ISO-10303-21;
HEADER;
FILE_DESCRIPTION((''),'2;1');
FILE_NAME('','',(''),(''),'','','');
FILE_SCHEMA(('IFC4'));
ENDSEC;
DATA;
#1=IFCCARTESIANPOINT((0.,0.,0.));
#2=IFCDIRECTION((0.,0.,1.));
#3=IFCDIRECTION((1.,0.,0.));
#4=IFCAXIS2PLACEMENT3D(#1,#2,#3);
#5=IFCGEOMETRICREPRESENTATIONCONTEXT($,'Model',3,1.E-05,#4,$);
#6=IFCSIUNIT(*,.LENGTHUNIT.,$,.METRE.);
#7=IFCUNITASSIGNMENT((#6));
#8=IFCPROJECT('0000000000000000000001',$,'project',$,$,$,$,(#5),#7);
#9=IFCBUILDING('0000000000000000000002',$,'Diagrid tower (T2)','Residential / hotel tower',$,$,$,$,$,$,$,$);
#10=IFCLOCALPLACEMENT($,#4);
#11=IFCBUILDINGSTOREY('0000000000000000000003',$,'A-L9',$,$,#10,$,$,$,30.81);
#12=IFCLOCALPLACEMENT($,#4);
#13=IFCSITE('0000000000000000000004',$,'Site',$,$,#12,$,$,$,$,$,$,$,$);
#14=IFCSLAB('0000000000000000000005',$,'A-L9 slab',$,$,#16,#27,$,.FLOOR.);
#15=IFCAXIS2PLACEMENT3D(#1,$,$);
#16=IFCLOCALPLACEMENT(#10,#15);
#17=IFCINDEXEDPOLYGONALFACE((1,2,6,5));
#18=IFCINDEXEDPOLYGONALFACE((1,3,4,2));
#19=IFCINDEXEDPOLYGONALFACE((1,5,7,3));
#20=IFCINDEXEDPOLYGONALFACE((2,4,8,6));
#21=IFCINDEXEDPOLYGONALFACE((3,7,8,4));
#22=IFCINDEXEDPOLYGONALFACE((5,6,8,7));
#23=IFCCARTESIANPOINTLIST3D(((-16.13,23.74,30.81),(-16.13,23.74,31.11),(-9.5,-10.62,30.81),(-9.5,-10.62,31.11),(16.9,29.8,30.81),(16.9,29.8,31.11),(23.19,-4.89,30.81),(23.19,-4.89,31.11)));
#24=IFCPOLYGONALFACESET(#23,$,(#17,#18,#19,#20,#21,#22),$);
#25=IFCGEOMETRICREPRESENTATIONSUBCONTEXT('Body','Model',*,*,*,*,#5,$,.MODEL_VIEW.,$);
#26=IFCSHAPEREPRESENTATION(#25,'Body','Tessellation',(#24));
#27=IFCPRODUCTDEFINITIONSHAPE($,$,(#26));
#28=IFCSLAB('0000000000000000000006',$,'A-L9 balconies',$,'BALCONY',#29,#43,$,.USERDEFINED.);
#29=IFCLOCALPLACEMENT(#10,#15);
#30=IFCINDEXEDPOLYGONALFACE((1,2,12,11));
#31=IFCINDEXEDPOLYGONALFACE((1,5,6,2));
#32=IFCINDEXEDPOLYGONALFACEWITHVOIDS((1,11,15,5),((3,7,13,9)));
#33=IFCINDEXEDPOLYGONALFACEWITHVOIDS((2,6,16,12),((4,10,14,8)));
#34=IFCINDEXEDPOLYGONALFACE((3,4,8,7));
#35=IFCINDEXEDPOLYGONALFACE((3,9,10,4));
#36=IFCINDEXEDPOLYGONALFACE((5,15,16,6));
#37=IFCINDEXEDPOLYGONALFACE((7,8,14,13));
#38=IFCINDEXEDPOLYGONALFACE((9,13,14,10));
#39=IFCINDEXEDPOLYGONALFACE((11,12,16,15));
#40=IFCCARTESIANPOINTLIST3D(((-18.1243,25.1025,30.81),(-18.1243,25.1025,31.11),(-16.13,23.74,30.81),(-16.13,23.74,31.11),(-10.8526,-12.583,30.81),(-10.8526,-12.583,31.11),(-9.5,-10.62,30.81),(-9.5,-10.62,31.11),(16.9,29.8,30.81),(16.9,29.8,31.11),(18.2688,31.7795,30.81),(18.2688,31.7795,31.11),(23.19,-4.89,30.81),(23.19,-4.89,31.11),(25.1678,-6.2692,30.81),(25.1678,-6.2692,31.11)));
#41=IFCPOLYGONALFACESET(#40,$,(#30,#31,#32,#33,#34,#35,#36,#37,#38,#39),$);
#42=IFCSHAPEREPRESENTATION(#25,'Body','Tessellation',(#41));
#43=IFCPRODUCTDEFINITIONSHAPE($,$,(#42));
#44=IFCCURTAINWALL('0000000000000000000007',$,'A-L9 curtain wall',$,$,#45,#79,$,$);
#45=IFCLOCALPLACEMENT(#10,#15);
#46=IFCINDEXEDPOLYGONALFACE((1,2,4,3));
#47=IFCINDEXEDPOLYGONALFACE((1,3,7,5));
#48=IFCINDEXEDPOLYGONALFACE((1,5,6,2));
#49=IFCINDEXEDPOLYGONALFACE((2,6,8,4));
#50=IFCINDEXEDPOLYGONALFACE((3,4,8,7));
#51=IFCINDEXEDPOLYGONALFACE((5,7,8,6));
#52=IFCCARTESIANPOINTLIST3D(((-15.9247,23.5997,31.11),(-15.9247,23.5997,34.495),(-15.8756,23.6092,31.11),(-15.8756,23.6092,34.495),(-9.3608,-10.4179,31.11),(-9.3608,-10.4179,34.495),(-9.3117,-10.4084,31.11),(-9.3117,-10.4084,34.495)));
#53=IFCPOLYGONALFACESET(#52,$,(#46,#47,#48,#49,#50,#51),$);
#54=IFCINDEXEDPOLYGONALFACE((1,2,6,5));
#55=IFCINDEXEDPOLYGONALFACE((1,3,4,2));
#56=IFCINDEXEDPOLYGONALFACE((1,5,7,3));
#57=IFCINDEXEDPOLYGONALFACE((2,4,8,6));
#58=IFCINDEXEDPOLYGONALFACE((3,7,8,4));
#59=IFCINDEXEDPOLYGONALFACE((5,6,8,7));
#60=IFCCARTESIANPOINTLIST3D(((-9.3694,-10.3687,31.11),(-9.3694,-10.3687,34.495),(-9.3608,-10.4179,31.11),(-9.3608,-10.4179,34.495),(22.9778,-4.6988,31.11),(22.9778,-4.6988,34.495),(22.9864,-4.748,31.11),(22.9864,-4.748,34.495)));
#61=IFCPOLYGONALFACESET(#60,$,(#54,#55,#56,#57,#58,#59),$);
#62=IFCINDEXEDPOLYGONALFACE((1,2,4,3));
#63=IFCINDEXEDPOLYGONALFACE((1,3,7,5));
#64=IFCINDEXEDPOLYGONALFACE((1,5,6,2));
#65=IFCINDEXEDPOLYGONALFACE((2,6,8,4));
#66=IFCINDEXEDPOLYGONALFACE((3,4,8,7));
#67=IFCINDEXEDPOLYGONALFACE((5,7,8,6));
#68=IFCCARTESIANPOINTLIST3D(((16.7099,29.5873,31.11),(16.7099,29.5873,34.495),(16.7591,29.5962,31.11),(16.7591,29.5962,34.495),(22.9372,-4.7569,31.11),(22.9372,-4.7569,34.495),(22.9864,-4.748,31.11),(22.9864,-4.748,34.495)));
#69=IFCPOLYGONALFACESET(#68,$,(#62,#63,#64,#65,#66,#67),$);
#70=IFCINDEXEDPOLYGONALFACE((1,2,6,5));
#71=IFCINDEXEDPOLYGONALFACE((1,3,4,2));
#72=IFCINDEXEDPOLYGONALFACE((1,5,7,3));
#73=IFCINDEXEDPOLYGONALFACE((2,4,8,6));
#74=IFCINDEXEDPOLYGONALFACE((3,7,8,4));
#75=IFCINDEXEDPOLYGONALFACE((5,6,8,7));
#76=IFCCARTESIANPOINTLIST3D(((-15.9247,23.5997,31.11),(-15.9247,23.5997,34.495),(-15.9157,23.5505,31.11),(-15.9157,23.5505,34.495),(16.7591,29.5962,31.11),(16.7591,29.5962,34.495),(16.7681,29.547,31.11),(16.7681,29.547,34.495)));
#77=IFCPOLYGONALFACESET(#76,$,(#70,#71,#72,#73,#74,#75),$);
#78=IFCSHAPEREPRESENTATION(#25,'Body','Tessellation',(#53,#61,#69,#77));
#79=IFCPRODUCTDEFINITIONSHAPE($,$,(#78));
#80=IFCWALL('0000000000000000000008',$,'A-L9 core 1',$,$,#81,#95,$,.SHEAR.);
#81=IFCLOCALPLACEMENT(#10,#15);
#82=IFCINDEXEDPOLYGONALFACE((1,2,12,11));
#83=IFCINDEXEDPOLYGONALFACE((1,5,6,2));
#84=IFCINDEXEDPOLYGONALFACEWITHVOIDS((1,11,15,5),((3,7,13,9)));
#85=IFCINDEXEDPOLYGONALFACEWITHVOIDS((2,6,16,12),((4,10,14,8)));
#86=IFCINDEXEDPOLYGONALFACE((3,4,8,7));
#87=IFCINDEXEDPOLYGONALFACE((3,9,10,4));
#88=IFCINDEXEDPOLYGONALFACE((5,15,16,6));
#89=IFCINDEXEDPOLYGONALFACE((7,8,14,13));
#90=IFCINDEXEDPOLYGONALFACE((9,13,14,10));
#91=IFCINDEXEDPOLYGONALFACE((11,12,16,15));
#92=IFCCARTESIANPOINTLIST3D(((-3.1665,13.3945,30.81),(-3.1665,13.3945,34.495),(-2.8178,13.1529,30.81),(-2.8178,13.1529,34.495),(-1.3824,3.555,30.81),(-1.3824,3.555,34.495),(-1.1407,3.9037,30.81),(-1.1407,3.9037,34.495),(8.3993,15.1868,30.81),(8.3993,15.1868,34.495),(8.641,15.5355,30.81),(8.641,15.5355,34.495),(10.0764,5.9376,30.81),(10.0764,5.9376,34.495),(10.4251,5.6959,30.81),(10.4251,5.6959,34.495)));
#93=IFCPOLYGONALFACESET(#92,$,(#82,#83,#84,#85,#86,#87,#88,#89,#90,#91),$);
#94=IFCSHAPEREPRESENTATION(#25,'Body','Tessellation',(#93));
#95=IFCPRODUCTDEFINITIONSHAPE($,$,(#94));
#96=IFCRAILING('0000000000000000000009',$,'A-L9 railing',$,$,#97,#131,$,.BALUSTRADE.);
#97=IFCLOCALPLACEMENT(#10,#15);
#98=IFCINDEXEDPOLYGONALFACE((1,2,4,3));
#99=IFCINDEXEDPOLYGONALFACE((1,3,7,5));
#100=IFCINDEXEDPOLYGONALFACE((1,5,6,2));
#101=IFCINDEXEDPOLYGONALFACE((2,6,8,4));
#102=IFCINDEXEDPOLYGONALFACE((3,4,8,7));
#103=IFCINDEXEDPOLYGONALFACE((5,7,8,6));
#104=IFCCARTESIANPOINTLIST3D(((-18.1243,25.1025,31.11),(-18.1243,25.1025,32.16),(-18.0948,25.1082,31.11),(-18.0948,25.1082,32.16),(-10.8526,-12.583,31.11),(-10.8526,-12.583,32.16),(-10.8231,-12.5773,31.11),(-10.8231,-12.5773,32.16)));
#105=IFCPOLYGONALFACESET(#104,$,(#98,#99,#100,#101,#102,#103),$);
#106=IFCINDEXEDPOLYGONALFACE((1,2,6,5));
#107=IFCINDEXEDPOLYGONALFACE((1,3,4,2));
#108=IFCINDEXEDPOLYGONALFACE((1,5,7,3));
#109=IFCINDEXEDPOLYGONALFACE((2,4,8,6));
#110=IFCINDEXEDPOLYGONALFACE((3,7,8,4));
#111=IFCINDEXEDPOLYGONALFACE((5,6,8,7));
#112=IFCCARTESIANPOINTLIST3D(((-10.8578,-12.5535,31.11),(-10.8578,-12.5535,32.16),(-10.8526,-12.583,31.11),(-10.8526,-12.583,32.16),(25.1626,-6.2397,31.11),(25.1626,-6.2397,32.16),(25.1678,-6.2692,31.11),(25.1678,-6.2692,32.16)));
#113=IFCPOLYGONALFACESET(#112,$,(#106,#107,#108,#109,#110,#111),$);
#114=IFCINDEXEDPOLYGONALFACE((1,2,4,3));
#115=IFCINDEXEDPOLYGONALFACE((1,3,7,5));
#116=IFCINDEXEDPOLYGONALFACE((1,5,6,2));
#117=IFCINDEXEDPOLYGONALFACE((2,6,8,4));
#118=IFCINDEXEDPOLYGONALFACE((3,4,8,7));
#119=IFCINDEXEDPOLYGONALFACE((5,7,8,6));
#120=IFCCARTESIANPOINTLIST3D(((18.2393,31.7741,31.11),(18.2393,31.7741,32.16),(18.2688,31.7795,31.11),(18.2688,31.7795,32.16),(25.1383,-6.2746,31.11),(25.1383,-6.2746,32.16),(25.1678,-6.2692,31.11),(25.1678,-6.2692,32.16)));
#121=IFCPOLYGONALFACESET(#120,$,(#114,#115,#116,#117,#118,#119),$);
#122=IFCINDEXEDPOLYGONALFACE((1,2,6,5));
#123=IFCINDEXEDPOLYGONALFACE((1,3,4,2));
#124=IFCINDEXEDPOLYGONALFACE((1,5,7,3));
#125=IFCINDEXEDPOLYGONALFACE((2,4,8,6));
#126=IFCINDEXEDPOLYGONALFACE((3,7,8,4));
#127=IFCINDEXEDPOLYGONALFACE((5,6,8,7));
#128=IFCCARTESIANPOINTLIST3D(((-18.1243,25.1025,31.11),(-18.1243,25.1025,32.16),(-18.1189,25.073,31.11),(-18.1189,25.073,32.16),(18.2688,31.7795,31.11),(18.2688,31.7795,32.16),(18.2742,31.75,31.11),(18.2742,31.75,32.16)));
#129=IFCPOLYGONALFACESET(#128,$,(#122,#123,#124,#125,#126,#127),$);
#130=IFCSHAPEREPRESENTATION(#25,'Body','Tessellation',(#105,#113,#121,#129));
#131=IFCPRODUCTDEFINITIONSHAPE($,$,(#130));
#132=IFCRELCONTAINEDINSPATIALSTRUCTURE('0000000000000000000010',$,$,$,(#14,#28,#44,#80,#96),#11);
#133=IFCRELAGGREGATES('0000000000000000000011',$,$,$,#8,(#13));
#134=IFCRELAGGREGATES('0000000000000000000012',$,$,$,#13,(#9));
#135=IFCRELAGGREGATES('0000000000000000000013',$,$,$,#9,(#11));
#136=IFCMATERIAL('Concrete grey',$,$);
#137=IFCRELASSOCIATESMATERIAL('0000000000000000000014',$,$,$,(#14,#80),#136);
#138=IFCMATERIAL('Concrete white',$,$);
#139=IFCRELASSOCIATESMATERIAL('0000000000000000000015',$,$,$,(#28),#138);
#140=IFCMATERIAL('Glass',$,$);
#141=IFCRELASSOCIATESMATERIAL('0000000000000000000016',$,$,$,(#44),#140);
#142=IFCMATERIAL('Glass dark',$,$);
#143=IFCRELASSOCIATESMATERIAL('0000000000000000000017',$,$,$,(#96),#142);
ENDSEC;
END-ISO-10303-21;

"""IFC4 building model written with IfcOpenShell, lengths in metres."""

from ifc_helpers import new_model, si_unit, frame, origin_with_axes, place, context, subcontext, project, spatial, polyline, outline, extrude, material, element, save


model = new_model("IFC4")

# Units and contexts
model_context = context("Model", 3, precision=1e-05, world=origin_with_axes())
body_context = subcontext(model_context, "Body", "Model", "MODEL_VIEW")
ifc_project = project(units=[si_unit("LENGTHUNIT", "METRE")], contexts=[model_context])

# Site, building, storey
site_placement = place(None, origin_with_axes())
site = spatial("IfcSite", under=ifc_project, at=site_placement, Name="Site")
building = spatial("IfcBuilding", under=site, Name="Diagrid tower (T2)", Description="Residential / hotel tower")
storey_placement = place(None, origin_with_axes())
storey = spatial("IfcBuildingStorey", under=building, at=storey_placement, Name="A-L9", Elevation=30.81)

# Slabs
ifc_material_1 = material(Name="Concrete grey")
slab_1_placement = place(storey_placement, origin_with_axes())
element("IfcSlab", 1, at=slab_1_placement, inside=storey, material=ifc_material_1, Name="A-L9 slab", PredefinedType="FLOOR", context=body_context, shape_type="SweptSolid", body=[
    extrude(outline(polyline([(-16.13, 23.74), (-9.5, -10.62), (23.19, -4.89), (16.9, 29.8), (-16.13, 23.74)])), frame((0.0, 0.0, 30.81), z_axis=(0.0, 0.0, 1.0), x_axis=(1.0, 0.0, 0.0)), (0.0, 0.0, 1.0), 0.3),
])
ifc_material_2 = material(Name="Concrete white")
slab_2_placement = place(storey_placement, origin_with_axes())
element("IfcSlab", 2, at=slab_2_placement, inside=storey, material=ifc_material_2, Name="A-L9 balconies", ObjectType="BALCONY", PredefinedType="USERDEFINED", context=body_context, shape_type="SweptSolid", body=[
    extrude(outline(polyline([(-18.1243, 25.1025), (-10.8526, -12.583), (25.1678, -6.2692), (18.2688, 31.7795), (-18.1243, 25.1025)]), holes=[polyline([(-16.13, 23.74), (-9.5, -10.62), (23.19, -4.89), (16.9, 29.8), (-16.13, 23.74)])]), frame((0.0, 0.0, 30.81), z_axis=(0.0, 0.0, 1.0), x_axis=(1.0, 0.0, 0.0)), (0.0, 0.0, 1.0), 0.3),
])

# Curtain wall
ifc_material_3 = material(Name="Glass")
curtain_wall_placement = place(storey_placement, origin_with_axes())
element("IfcCurtainWall", 3, at=curtain_wall_placement, inside=storey, material=ifc_material_3, Name="A-L9 curtain wall", context=body_context, shape_type="SweptSolid", body=[
    extrude(outline(polyline([(-15.9247, 23.5997), (-9.3608, -10.4179), (-9.3117, -10.4084), (-15.8756, 23.6092), (-15.9247, 23.5997)])), frame((0.0, 0.0, 31.11), z_axis=(0.0, 0.0, 1.0), x_axis=(1.0, 0.0, 0.0)), (0.0, 0.0, 1.0), 3.385),
    extrude(outline(polyline([(-9.3608, -10.4179), (22.9864, -4.748), (22.9778, -4.6988), (-9.3694, -10.3687), (-9.3608, -10.4179)])), frame((0.0, 0.0, 31.11), z_axis=(0.0, 0.0, 1.0), x_axis=(1.0, 0.0, 0.0)), (0.0, 0.0, 1.0), 3.385),
    extrude(outline(polyline([(22.9864, -4.748), (16.7591, 29.5962), (16.7099, 29.5873), (22.9372, -4.7569), (22.9864, -4.748)])), frame((0.0, 0.0, 31.11), z_axis=(0.0, 0.0, 1.0), x_axis=(1.0, 0.0, 0.0)), (0.0, 0.0, 1.0), 3.385),
    extrude(outline(polyline([(16.7591, 29.5962), (-15.9247, 23.5997), (-15.9157, 23.5505), (16.7681, 29.547), (16.7591, 29.5962)])), frame((0.0, 0.0, 31.11), z_axis=(0.0, 0.0, 1.0), x_axis=(1.0, 0.0, 0.0)), (0.0, 0.0, 1.0), 3.385),
])

# Wall
wall_placement = place(storey_placement, origin_with_axes())
element("IfcWall", 4, at=wall_placement, inside=storey, material=ifc_material_1, Name="A-L9 core 1", PredefinedType="SHEAR", context=body_context, shape_type="SweptSolid", body=[
    extrude(outline(polyline([(10.4251, 5.6959), (8.641, 15.5355), (-3.1665, 13.3945), (-1.3824, 3.555), (10.4251, 5.6959)]), holes=[polyline([(10.0764, 5.9376), (8.3993, 15.1868), (-2.8178, 13.1529), (-1.1407, 3.9037), (10.0764, 5.9376)])]), frame((0.0, 0.0, 30.81), z_axis=(0.0, 0.0, 1.0), x_axis=(1.0, 0.0, 0.0)), (0.0, 0.0, 1.0), 3.685),
])

# Railing
ifc_material_4 = material(Name="Glass dark")
railing_placement = place(storey_placement, origin_with_axes())
element("IfcRailing", 5, at=railing_placement, inside=storey, material=ifc_material_4, Name="A-L9 railing", PredefinedType="BALUSTRADE", context=body_context, shape_type="SweptSolid", body=[
    extrude(outline(polyline([(-18.1243, 25.1025), (-10.8526, -12.583), (-10.8231, -12.5773), (-18.0948, 25.1082), (-18.1243, 25.1025)])), frame((0.0, 0.0, 31.11), z_axis=(0.0, 0.0, 1.0), x_axis=(1.0, 0.0, 0.0)), (0.0, 0.0, 1.0), 1.05),
    extrude(outline(polyline([(-10.8526, -12.583), (25.1678, -6.2692), (25.1626, -6.2397), (-10.8578, -12.5535), (-10.8526, -12.583)])), frame((0.0, 0.0, 31.11), z_axis=(0.0, 0.0, 1.0), x_axis=(1.0, 0.0, 0.0)), (0.0, 0.0, 1.0), 1.05),
    extrude(outline(polyline([(25.1678, -6.2692), (18.2688, 31.7795), (18.2393, 31.7741), (25.1383, -6.2746), (25.1678, -6.2692)])), frame((0.0, 0.0, 31.11), z_axis=(0.0, 0.0, 1.0), x_axis=(1.0, 0.0, 0.0)), (0.0, 0.0, 1.0), 1.05),
    extrude(outline(polyline([(18.2688, 31.7795), (-18.1243, 25.1025), (-18.1189, 25.073), (18.2742, 31.75), (18.2688, 31.7795)])), frame((0.0, 0.0, 31.11), z_axis=(0.0, 0.0, 1.0), x_axis=(1.0, 0.0, 0.0)), (0.0, 0.0, 1.0), 1.05),
])

save(model, "model.ifc")
